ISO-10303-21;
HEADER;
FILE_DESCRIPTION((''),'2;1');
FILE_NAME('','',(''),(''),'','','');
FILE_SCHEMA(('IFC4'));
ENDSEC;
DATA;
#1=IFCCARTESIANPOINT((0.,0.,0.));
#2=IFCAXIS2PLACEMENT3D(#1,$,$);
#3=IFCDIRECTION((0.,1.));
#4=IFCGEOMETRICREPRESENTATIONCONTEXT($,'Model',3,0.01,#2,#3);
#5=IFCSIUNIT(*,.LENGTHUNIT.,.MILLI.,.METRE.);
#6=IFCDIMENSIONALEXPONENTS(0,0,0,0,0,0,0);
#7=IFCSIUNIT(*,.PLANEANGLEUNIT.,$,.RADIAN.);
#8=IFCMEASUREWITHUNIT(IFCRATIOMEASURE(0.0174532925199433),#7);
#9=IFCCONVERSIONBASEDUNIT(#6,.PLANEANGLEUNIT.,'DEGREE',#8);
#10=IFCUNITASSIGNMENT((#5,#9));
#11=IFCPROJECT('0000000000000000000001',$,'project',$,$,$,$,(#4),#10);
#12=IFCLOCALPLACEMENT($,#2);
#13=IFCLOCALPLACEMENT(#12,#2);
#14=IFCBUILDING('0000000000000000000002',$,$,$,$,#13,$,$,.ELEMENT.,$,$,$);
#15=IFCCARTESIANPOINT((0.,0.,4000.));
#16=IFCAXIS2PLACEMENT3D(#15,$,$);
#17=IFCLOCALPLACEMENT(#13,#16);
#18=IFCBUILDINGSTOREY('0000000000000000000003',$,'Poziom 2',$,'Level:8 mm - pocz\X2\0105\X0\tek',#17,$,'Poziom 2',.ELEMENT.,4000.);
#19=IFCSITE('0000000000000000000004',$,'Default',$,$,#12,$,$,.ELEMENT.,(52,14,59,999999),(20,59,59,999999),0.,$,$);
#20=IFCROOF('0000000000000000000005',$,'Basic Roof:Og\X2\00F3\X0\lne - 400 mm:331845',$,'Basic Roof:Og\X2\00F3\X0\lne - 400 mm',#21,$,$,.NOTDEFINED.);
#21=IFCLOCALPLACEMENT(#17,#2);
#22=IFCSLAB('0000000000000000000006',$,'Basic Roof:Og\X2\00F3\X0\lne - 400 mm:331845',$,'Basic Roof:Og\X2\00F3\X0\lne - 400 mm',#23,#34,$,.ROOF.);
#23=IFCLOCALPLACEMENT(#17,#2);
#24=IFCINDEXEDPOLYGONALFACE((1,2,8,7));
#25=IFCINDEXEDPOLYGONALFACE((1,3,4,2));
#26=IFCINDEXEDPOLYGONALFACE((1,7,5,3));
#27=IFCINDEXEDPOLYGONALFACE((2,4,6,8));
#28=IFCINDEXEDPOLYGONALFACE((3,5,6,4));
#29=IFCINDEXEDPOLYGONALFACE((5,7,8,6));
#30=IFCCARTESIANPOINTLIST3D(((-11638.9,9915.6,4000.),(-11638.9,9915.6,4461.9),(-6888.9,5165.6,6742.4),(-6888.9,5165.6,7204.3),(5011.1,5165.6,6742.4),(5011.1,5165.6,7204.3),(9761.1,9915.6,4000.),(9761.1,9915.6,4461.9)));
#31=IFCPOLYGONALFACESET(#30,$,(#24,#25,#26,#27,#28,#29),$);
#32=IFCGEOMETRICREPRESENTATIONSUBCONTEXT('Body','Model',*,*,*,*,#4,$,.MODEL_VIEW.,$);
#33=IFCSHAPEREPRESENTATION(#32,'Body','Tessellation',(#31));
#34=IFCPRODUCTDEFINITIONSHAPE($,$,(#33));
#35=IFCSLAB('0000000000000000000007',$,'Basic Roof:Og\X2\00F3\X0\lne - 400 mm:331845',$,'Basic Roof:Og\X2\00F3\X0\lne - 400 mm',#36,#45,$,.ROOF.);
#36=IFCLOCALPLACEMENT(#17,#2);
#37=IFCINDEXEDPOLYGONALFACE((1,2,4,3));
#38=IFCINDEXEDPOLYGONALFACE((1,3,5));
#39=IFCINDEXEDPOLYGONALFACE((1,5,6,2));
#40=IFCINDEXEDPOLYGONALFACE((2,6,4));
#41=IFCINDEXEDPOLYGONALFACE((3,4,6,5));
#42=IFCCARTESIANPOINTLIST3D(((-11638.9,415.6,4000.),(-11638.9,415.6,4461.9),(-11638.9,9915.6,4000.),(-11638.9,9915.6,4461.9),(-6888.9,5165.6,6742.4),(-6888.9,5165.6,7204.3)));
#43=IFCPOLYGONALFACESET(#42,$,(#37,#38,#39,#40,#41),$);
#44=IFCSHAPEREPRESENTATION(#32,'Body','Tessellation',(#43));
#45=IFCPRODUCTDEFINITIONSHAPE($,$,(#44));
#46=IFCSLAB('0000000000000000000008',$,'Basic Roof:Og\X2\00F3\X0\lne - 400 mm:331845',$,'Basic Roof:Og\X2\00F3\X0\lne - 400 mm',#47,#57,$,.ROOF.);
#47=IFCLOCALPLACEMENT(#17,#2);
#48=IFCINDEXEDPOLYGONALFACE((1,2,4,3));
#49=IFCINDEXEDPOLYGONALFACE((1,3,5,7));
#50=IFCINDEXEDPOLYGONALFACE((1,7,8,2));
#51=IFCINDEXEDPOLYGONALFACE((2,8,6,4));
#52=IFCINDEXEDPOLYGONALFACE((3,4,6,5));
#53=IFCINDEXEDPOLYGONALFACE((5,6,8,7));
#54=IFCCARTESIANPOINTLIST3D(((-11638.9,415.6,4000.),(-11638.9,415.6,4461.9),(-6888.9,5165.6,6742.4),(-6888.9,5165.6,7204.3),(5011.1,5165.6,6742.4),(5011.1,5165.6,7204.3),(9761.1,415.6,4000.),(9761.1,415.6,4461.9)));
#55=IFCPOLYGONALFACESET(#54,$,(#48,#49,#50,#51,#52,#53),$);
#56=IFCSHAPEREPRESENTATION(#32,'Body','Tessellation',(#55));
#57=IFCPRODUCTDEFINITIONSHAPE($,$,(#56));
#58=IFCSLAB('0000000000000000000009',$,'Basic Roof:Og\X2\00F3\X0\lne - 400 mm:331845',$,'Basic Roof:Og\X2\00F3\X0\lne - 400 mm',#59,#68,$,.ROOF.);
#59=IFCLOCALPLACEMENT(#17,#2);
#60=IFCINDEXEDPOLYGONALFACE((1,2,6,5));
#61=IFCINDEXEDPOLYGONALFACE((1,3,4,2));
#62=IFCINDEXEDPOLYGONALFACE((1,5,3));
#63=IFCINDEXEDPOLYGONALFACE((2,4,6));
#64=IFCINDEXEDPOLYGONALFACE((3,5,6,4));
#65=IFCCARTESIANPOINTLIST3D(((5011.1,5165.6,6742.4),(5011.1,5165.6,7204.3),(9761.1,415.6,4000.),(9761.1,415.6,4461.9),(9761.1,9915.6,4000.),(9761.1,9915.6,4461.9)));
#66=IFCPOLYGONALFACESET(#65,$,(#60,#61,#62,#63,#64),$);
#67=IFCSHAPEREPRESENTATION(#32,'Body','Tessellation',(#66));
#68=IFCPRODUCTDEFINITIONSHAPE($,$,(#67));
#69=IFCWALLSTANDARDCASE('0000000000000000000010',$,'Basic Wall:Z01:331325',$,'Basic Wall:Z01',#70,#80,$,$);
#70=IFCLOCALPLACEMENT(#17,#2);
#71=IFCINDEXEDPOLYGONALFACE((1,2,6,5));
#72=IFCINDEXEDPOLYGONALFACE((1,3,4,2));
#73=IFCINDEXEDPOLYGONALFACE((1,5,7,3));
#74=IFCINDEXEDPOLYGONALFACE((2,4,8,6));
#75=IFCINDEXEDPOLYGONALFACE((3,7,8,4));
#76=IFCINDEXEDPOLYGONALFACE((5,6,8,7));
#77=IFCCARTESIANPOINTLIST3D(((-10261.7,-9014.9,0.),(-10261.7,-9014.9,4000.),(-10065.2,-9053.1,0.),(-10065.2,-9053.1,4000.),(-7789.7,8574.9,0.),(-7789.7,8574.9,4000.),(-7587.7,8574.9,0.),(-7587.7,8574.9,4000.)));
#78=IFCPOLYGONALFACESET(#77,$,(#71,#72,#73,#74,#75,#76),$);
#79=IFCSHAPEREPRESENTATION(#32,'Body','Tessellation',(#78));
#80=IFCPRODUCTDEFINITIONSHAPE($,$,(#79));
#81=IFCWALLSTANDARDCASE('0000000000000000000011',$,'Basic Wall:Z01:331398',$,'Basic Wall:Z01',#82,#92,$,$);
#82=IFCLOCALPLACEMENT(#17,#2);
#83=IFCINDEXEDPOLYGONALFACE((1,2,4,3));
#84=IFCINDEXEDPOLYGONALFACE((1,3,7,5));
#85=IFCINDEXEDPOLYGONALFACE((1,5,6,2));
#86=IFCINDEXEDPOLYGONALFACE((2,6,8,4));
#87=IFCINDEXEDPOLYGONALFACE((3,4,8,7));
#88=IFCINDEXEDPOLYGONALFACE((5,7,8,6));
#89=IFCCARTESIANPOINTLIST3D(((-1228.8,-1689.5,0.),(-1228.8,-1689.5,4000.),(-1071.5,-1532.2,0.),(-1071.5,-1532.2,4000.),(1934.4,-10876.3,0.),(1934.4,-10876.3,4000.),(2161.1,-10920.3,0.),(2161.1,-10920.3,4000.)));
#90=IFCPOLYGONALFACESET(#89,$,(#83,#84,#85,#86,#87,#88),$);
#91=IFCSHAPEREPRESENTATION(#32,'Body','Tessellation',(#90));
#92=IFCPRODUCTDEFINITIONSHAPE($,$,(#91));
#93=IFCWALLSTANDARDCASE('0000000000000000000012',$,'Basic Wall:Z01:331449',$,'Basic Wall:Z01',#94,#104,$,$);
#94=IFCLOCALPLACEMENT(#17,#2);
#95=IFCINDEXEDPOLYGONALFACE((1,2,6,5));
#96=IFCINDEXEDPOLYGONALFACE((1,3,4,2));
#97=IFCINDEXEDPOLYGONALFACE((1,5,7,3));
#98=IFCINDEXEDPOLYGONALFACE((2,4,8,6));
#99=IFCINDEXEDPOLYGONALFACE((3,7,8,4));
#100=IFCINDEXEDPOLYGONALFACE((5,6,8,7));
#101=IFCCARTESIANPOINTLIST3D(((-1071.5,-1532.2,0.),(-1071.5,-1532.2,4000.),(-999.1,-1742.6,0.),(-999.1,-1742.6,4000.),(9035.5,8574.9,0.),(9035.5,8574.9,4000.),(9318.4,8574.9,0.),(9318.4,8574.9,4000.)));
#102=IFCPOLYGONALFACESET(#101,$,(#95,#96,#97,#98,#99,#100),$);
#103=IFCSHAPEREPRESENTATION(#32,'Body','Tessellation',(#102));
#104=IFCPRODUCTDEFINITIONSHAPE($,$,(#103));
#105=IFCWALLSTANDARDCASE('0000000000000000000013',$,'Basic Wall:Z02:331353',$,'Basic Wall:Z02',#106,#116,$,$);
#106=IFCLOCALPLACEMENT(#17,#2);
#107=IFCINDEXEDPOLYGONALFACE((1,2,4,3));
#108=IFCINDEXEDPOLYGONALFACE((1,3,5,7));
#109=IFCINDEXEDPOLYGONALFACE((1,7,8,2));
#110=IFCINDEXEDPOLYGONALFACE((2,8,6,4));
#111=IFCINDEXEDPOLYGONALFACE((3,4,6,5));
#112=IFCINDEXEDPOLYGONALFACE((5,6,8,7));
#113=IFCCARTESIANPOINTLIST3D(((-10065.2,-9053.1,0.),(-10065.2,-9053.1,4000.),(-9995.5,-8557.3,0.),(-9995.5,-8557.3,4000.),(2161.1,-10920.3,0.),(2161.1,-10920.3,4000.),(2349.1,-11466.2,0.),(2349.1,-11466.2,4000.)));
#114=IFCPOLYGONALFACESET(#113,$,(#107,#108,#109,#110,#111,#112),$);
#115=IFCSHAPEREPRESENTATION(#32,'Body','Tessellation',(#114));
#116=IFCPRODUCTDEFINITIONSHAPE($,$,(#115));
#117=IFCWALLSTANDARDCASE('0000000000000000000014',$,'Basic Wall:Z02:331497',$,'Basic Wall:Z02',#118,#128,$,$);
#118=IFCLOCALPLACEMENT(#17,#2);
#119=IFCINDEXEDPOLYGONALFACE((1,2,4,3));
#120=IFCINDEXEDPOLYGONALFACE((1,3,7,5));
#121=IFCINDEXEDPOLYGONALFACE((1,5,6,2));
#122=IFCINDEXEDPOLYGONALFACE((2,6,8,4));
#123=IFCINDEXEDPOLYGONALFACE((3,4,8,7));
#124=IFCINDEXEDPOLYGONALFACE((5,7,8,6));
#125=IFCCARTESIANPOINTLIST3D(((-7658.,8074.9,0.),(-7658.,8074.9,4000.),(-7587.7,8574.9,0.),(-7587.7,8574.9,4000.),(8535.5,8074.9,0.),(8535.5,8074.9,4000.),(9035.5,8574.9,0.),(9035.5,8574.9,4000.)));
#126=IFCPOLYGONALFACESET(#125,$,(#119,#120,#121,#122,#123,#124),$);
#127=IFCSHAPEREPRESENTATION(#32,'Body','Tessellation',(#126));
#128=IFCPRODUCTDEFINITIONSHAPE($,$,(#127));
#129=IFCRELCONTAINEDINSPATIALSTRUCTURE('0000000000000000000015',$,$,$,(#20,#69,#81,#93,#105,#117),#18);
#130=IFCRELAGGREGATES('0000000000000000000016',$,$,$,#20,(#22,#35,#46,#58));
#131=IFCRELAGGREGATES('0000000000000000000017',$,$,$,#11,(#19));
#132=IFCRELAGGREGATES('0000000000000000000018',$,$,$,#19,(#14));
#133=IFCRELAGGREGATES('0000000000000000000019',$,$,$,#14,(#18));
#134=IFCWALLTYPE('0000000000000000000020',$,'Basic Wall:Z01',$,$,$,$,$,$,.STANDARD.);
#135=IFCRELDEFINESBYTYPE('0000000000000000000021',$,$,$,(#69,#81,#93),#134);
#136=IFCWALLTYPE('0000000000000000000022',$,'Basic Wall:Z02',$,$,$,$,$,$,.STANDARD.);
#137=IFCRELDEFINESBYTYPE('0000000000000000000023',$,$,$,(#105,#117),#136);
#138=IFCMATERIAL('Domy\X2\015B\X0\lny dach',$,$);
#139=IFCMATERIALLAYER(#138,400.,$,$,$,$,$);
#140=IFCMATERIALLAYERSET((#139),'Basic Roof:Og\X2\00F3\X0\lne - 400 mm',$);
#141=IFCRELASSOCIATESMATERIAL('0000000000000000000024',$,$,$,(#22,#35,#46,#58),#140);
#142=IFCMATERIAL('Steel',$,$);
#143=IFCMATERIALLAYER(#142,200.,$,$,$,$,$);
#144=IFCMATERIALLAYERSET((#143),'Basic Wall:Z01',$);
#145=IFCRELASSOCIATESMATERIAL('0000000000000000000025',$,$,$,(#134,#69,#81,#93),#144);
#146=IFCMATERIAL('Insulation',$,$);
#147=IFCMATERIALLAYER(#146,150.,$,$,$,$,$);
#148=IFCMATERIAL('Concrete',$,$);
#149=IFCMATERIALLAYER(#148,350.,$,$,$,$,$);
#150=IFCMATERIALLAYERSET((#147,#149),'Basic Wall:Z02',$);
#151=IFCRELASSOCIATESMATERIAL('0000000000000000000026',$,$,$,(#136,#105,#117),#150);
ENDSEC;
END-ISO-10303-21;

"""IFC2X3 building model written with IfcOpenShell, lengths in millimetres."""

from ifc_helpers import new_model, entity, si_unit, converted_unit, direction, frame, origin, place, context, subcontext, project, spatial, polyline, outline, extrude, clip, halfspace, material, layer, layer_set, layer_usage, type_object, element, aggregate, save


model = new_model("IFC2X3")

# Units and contexts
model_context = context("Model", 3, precision=0.01, world=origin(), true_north=direction((0.0, 1.0)))
body_context = subcontext(model_context, "Body", "Model", "MODEL_VIEW")
ifc_project = project(units=[si_unit("LENGTHUNIT", "METRE", prefix="MILLI"), converted_unit("PLANEANGLEUNIT", "DEGREE", entity("IfcRatioMeasure", 0.0174532925199433), si_unit("PLANEANGLEUNIT", "RADIAN"), dimensions=[0, 0, 0, 0, 0, 0, 0])], contexts=[model_context])

# Site, building, storey
site_placement = place(None, origin())
site = spatial("IfcSite", under=ifc_project, at=site_placement, Name="Default", CompositionType="ELEMENT", RefLatitude=(52, 14, 59, 999999), RefLongitude=(20, 59, 59, 999999), RefElevation=0.0)
building_placement = place(site_placement, origin())
building = spatial("IfcBuilding", under=site, at=building_placement, CompositionType="ELEMENT")
storey_placement = place(building_placement, frame((0.0, 0.0, 4000.0)))
storey = spatial("IfcBuildingStorey", under=building, at=storey_placement, Name="Poziom 2", ObjectType="Level:8 mm - początek", LongName="Poziom 2", CompositionType="ELEMENT", Elevation=4000.0)

# Roof, slabs
roof_placement = place(storey_placement, frame((-11638.9, 415.6, 4000.0)))
roof = element("IfcRoof", 1, at=roof_placement, inside=storey, Name="Basic Roof:Ogólne - 400 mm:331845", ObjectType="Basic Roof:Ogólne - 400 mm", ShapeType="NOTDEFINED")
ifc_material_1 = material(Name="Domyślny dach")
ifc_layer_1 = layer(ifc_material_1, 400.0)
ifc_layer_set_1 = layer_set([ifc_layer_1], Name="Basic Roof:Ogólne - 400 mm")
slab_1_placement = place(roof_placement, origin())
slab_1 = element("IfcSlab", 2, at=slab_1_placement, material=ifc_layer_set_1, Name="Basic Roof:Ogólne - 400 mm:331845", ObjectType="Basic Roof:Ogólne - 400 mm", PredefinedType="ROOF", context=body_context, shape_type="SweptSolid", body=[
    extrude(outline(polyline([(10700.0, 2742.4), (-10700.0, 2742.4), (-5950.0, -2742.4), (5950.0, -2742.4), (10700.0, 2742.4)])), frame((10700.0, 7125.0, 1371.2), z_axis=(0.0, 0.5, 0.866025), x_axis=(1.0, 0.0, 0.0)), (0.0, -0.5, 0.866025), 461.9),
])
slab_2_placement = place(roof_placement, origin())
slab_2 = element("IfcSlab", 3, at=slab_2_placement, material=ifc_layer_set_1, Name="Basic Roof:Ogólne - 400 mm:331845", ObjectType="Basic Roof:Ogólne - 400 mm", PredefinedType="ROOF", context=body_context, shape_type="SweptSolid", body=[
    extrude(outline(polyline([(-2742.4, 4750.0), (-2742.4, -4750.0), (2742.4, 0.0), (-2742.4, 4750.0)])), frame((2375.0, 4750.0, 1371.2), z_axis=(-0.5, 0.0, 0.866025), x_axis=(0.866025, 0.0, 0.5)), (0.5, 0.0, 0.866025), 461.9),
])
slab_3_placement = place(roof_placement, origin())
slab_3 = element("IfcSlab", 4, at=slab_3_placement, material=ifc_layer_set_1, Name="Basic Roof:Ogólne - 400 mm:331845", ObjectType="Basic Roof:Ogólne - 400 mm", PredefinedType="ROOF", context=body_context, shape_type="SweptSolid", body=[
    extrude(outline(polyline([(-10700.0, -2742.4), (10700.0, -2742.4), (5950.0, 2742.4), (-5950.0, 2742.4), (-10700.0, -2742.4)])), frame((10700.0, 2375.0, 1371.2), z_axis=(0.0, -0.5, 0.866025), x_axis=(1.0, 0.0, 0.0)), (0.0, 0.5, 0.866025), 461.9),
])
slab_4_placement = place(roof_placement, origin())
slab_4 = element("IfcSlab", 5, at=slab_4_placement, material=ifc_layer_set_1, Name="Basic Roof:Ogólne - 400 mm:331845", ObjectType="Basic Roof:Ogólne - 400 mm", PredefinedType="ROOF", context=body_context, shape_type="SweptSolid", body=[
    extrude(outline(polyline([(-2742.4, 0.0), (2742.4, -4750.0), (2742.4, 4750.0), (-2742.4, 0.0)])), frame((19025.0, 4750.0, 1371.2), z_axis=(0.5, 0.0, 0.866025), x_axis=(0.866025, 0.0, -0.5)), (-0.5, 0.0, 0.866025), 461.9),
])
aggregate(roof, [slab_1, slab_2, slab_3, slab_4])

# Walls
ifc_material_2 = material(Name="Steel")
ifc_layer_2 = layer(ifc_material_2, 200.0)
ifc_layer_set_2 = layer_set([ifc_layer_2], Name="Basic Wall:Z01")
ifc_layer_usage_1 = layer_usage(ifc_layer_set_2, "AXIS2", "NEGATIVE", 100.0)
wall_type_1 = type_object("IfcWallType", Name="Basic Wall:Z01", PredefinedType="STANDARD", material=ifc_layer_set_2)
wall_1_placement = place(storey_placement, frame((-7686.7, 8588.8, 0.0), z_axis=(0.0, 0.0, 1.0), x_axis=(-0.139173, -0.990268, 0.0)))
element("IfcWallStandardCase", 6, at=wall_1_placement, inside=storey, type_object=wall_type_1, material=ifc_layer_usage_1, Name="Basic Wall:Z01:331325", ObjectType="Basic Wall:Z01", context=body_context, shape_type="Clipping", body=[
    clip(extrude(outline(polyline([(17790.8, -100.0), (17801.2, 100.0), (17300.6, 100.0), (504.9, 100.0), (0.0, 100.0), (28.1, -100.0), (17790.8, -100.0)])), origin(), (0.0, 0.0, 1.0), 4000.0), halfspace(frame((0.0, 0.0, -4000.0)), True)),
])
ifc_layer_usage_2 = layer_usage(ifc_layer_set_2, "AXIS2", "NEGATIVE", 100.0)
wall_2_placement = place(storey_placement, frame((2066.5, -10952.9, 0.0), z_axis=(0.0, 0.0, 1.0), x_axis=(-0.325568, 0.945519, 0.0)))
element("IfcWallStandardCase", 7, at=wall_2_placement, inside=storey, type_object=wall_type_1, material=ifc_layer_usage_2, Name="Basic Wall:Z01:331398", ObjectType="Basic Wall:Z01", context=body_context, shape_type="Clipping", body=[
    clip(extrude(outline(polyline([(9929.1, -100.0), (9831.5, 100.0), (115.5, 100.0), (0.0, -100.0), (9706.6, -100.0), (9929.1, -100.0)])), origin(), (0.0, 0.0, 1.0), 4000.0), halfspace(frame((0.0, 0.0, -4000.0)), True)),
])
ifc_layer_usage_3 = layer_usage(ifc_layer_set_2, "AXIS2", "NEGATIVE", 100.0)
wall_3_placement = place(storey_placement, frame((-1069.8, -1671.9, 0.0), z_axis=(0.0, 0.0, 1.0), x_axis=(0.707107, 0.707107, 0.0)))
element("IfcWallStandardCase", 8, at=wall_3_placement, inside=storey, type_object=wall_type_1, material=ifc_layer_usage_3, Name="Basic Wall:Z01:331449", ObjectType="Basic Wall:Z01", context=body_context, shape_type="Clipping", body=[
    clip(extrude(outline(polyline([(14591.1, -100.0), (14391.1, 100.0), (13684.0, 100.0), (97.5, 100.0), (0.0, -100.0), (14591.1, -100.0)])), origin(), (0.0, 0.0, 1.0), 4000.0), halfspace(frame((0.0, 0.0, -4000.0)), True)),
])
ifc_material_3 = material(Name="Insulation")
ifc_layer_3 = layer(ifc_material_3, 150.0)
ifc_material_4 = material(Name="Concrete")
ifc_layer_4 = layer(ifc_material_4, 350.0)
ifc_layer_set_3 = layer_set([ifc_layer_3, ifc_layer_4], Name="Basic Wall:Z02")
ifc_layer_usage_4 = layer_usage(ifc_layer_set_3, "AXIS2", "NEGATIVE", 250.0)
wall_type_2 = type_object("IfcWallType", Name="Basic Wall:Z02", PredefinedType="STANDARD", material=ifc_layer_set_3)
wall_4_placement = place(storey_placement, frame((-10043.2, -8802.7, 0.0), z_axis=(0.0, 0.0, 1.0), x_axis=(0.981627, -0.190809, 0.0)))
element("IfcWallStandardCase", 9, at=wall_4_placement, inside=storey, type_object=wall_type_2, material=ifc_layer_usage_4, Name="Basic Wall:Z02:331353", ObjectType="Basic Wall:Z02", context=body_context, shape_type="Clipping", body=[
    clip(extrude(outline(polyline([(26.2, -250.0), (12672.8, -250.0), (12384.1, 250.0), (12153.2, 250.0), (0.0, 250.0), (26.2, -250.0)])), origin(), (0.0, 0.0, 1.0), 4000.0), halfspace(frame((0.0, 0.0, -4000.0)), True)),
])
ifc_layer_usage_5 = layer_usage(ifc_layer_set_3, "AXIS2", "NEGATIVE", 250.0)
wall_5_placement = place(storey_placement, frame((9035.5, 8324.9, 0.0), z_axis=(0.0, 0.0, 1.0), x_axis=(-1.0, 0.0, 0.0)))
element("IfcWallStandardCase", 10, at=wall_5_placement, inside=storey, type_object=wall_type_2, material=ifc_layer_usage_5, Name="Basic Wall:Z02:331497", ObjectType="Basic Wall:Z02", context=body_context, shape_type="Clipping", body=[
    clip(extrude(outline(polyline([(16623.2, -250.0), (16693.5, 250.0), (500.0, 250.0), (0.0, -250.0), (16623.2, -250.0)])), origin(), (0.0, 0.0, 1.0), 4000.0), halfspace(frame((0.0, 0.0, -4000.0)), True)),
])

save(model, "model.ifc")
